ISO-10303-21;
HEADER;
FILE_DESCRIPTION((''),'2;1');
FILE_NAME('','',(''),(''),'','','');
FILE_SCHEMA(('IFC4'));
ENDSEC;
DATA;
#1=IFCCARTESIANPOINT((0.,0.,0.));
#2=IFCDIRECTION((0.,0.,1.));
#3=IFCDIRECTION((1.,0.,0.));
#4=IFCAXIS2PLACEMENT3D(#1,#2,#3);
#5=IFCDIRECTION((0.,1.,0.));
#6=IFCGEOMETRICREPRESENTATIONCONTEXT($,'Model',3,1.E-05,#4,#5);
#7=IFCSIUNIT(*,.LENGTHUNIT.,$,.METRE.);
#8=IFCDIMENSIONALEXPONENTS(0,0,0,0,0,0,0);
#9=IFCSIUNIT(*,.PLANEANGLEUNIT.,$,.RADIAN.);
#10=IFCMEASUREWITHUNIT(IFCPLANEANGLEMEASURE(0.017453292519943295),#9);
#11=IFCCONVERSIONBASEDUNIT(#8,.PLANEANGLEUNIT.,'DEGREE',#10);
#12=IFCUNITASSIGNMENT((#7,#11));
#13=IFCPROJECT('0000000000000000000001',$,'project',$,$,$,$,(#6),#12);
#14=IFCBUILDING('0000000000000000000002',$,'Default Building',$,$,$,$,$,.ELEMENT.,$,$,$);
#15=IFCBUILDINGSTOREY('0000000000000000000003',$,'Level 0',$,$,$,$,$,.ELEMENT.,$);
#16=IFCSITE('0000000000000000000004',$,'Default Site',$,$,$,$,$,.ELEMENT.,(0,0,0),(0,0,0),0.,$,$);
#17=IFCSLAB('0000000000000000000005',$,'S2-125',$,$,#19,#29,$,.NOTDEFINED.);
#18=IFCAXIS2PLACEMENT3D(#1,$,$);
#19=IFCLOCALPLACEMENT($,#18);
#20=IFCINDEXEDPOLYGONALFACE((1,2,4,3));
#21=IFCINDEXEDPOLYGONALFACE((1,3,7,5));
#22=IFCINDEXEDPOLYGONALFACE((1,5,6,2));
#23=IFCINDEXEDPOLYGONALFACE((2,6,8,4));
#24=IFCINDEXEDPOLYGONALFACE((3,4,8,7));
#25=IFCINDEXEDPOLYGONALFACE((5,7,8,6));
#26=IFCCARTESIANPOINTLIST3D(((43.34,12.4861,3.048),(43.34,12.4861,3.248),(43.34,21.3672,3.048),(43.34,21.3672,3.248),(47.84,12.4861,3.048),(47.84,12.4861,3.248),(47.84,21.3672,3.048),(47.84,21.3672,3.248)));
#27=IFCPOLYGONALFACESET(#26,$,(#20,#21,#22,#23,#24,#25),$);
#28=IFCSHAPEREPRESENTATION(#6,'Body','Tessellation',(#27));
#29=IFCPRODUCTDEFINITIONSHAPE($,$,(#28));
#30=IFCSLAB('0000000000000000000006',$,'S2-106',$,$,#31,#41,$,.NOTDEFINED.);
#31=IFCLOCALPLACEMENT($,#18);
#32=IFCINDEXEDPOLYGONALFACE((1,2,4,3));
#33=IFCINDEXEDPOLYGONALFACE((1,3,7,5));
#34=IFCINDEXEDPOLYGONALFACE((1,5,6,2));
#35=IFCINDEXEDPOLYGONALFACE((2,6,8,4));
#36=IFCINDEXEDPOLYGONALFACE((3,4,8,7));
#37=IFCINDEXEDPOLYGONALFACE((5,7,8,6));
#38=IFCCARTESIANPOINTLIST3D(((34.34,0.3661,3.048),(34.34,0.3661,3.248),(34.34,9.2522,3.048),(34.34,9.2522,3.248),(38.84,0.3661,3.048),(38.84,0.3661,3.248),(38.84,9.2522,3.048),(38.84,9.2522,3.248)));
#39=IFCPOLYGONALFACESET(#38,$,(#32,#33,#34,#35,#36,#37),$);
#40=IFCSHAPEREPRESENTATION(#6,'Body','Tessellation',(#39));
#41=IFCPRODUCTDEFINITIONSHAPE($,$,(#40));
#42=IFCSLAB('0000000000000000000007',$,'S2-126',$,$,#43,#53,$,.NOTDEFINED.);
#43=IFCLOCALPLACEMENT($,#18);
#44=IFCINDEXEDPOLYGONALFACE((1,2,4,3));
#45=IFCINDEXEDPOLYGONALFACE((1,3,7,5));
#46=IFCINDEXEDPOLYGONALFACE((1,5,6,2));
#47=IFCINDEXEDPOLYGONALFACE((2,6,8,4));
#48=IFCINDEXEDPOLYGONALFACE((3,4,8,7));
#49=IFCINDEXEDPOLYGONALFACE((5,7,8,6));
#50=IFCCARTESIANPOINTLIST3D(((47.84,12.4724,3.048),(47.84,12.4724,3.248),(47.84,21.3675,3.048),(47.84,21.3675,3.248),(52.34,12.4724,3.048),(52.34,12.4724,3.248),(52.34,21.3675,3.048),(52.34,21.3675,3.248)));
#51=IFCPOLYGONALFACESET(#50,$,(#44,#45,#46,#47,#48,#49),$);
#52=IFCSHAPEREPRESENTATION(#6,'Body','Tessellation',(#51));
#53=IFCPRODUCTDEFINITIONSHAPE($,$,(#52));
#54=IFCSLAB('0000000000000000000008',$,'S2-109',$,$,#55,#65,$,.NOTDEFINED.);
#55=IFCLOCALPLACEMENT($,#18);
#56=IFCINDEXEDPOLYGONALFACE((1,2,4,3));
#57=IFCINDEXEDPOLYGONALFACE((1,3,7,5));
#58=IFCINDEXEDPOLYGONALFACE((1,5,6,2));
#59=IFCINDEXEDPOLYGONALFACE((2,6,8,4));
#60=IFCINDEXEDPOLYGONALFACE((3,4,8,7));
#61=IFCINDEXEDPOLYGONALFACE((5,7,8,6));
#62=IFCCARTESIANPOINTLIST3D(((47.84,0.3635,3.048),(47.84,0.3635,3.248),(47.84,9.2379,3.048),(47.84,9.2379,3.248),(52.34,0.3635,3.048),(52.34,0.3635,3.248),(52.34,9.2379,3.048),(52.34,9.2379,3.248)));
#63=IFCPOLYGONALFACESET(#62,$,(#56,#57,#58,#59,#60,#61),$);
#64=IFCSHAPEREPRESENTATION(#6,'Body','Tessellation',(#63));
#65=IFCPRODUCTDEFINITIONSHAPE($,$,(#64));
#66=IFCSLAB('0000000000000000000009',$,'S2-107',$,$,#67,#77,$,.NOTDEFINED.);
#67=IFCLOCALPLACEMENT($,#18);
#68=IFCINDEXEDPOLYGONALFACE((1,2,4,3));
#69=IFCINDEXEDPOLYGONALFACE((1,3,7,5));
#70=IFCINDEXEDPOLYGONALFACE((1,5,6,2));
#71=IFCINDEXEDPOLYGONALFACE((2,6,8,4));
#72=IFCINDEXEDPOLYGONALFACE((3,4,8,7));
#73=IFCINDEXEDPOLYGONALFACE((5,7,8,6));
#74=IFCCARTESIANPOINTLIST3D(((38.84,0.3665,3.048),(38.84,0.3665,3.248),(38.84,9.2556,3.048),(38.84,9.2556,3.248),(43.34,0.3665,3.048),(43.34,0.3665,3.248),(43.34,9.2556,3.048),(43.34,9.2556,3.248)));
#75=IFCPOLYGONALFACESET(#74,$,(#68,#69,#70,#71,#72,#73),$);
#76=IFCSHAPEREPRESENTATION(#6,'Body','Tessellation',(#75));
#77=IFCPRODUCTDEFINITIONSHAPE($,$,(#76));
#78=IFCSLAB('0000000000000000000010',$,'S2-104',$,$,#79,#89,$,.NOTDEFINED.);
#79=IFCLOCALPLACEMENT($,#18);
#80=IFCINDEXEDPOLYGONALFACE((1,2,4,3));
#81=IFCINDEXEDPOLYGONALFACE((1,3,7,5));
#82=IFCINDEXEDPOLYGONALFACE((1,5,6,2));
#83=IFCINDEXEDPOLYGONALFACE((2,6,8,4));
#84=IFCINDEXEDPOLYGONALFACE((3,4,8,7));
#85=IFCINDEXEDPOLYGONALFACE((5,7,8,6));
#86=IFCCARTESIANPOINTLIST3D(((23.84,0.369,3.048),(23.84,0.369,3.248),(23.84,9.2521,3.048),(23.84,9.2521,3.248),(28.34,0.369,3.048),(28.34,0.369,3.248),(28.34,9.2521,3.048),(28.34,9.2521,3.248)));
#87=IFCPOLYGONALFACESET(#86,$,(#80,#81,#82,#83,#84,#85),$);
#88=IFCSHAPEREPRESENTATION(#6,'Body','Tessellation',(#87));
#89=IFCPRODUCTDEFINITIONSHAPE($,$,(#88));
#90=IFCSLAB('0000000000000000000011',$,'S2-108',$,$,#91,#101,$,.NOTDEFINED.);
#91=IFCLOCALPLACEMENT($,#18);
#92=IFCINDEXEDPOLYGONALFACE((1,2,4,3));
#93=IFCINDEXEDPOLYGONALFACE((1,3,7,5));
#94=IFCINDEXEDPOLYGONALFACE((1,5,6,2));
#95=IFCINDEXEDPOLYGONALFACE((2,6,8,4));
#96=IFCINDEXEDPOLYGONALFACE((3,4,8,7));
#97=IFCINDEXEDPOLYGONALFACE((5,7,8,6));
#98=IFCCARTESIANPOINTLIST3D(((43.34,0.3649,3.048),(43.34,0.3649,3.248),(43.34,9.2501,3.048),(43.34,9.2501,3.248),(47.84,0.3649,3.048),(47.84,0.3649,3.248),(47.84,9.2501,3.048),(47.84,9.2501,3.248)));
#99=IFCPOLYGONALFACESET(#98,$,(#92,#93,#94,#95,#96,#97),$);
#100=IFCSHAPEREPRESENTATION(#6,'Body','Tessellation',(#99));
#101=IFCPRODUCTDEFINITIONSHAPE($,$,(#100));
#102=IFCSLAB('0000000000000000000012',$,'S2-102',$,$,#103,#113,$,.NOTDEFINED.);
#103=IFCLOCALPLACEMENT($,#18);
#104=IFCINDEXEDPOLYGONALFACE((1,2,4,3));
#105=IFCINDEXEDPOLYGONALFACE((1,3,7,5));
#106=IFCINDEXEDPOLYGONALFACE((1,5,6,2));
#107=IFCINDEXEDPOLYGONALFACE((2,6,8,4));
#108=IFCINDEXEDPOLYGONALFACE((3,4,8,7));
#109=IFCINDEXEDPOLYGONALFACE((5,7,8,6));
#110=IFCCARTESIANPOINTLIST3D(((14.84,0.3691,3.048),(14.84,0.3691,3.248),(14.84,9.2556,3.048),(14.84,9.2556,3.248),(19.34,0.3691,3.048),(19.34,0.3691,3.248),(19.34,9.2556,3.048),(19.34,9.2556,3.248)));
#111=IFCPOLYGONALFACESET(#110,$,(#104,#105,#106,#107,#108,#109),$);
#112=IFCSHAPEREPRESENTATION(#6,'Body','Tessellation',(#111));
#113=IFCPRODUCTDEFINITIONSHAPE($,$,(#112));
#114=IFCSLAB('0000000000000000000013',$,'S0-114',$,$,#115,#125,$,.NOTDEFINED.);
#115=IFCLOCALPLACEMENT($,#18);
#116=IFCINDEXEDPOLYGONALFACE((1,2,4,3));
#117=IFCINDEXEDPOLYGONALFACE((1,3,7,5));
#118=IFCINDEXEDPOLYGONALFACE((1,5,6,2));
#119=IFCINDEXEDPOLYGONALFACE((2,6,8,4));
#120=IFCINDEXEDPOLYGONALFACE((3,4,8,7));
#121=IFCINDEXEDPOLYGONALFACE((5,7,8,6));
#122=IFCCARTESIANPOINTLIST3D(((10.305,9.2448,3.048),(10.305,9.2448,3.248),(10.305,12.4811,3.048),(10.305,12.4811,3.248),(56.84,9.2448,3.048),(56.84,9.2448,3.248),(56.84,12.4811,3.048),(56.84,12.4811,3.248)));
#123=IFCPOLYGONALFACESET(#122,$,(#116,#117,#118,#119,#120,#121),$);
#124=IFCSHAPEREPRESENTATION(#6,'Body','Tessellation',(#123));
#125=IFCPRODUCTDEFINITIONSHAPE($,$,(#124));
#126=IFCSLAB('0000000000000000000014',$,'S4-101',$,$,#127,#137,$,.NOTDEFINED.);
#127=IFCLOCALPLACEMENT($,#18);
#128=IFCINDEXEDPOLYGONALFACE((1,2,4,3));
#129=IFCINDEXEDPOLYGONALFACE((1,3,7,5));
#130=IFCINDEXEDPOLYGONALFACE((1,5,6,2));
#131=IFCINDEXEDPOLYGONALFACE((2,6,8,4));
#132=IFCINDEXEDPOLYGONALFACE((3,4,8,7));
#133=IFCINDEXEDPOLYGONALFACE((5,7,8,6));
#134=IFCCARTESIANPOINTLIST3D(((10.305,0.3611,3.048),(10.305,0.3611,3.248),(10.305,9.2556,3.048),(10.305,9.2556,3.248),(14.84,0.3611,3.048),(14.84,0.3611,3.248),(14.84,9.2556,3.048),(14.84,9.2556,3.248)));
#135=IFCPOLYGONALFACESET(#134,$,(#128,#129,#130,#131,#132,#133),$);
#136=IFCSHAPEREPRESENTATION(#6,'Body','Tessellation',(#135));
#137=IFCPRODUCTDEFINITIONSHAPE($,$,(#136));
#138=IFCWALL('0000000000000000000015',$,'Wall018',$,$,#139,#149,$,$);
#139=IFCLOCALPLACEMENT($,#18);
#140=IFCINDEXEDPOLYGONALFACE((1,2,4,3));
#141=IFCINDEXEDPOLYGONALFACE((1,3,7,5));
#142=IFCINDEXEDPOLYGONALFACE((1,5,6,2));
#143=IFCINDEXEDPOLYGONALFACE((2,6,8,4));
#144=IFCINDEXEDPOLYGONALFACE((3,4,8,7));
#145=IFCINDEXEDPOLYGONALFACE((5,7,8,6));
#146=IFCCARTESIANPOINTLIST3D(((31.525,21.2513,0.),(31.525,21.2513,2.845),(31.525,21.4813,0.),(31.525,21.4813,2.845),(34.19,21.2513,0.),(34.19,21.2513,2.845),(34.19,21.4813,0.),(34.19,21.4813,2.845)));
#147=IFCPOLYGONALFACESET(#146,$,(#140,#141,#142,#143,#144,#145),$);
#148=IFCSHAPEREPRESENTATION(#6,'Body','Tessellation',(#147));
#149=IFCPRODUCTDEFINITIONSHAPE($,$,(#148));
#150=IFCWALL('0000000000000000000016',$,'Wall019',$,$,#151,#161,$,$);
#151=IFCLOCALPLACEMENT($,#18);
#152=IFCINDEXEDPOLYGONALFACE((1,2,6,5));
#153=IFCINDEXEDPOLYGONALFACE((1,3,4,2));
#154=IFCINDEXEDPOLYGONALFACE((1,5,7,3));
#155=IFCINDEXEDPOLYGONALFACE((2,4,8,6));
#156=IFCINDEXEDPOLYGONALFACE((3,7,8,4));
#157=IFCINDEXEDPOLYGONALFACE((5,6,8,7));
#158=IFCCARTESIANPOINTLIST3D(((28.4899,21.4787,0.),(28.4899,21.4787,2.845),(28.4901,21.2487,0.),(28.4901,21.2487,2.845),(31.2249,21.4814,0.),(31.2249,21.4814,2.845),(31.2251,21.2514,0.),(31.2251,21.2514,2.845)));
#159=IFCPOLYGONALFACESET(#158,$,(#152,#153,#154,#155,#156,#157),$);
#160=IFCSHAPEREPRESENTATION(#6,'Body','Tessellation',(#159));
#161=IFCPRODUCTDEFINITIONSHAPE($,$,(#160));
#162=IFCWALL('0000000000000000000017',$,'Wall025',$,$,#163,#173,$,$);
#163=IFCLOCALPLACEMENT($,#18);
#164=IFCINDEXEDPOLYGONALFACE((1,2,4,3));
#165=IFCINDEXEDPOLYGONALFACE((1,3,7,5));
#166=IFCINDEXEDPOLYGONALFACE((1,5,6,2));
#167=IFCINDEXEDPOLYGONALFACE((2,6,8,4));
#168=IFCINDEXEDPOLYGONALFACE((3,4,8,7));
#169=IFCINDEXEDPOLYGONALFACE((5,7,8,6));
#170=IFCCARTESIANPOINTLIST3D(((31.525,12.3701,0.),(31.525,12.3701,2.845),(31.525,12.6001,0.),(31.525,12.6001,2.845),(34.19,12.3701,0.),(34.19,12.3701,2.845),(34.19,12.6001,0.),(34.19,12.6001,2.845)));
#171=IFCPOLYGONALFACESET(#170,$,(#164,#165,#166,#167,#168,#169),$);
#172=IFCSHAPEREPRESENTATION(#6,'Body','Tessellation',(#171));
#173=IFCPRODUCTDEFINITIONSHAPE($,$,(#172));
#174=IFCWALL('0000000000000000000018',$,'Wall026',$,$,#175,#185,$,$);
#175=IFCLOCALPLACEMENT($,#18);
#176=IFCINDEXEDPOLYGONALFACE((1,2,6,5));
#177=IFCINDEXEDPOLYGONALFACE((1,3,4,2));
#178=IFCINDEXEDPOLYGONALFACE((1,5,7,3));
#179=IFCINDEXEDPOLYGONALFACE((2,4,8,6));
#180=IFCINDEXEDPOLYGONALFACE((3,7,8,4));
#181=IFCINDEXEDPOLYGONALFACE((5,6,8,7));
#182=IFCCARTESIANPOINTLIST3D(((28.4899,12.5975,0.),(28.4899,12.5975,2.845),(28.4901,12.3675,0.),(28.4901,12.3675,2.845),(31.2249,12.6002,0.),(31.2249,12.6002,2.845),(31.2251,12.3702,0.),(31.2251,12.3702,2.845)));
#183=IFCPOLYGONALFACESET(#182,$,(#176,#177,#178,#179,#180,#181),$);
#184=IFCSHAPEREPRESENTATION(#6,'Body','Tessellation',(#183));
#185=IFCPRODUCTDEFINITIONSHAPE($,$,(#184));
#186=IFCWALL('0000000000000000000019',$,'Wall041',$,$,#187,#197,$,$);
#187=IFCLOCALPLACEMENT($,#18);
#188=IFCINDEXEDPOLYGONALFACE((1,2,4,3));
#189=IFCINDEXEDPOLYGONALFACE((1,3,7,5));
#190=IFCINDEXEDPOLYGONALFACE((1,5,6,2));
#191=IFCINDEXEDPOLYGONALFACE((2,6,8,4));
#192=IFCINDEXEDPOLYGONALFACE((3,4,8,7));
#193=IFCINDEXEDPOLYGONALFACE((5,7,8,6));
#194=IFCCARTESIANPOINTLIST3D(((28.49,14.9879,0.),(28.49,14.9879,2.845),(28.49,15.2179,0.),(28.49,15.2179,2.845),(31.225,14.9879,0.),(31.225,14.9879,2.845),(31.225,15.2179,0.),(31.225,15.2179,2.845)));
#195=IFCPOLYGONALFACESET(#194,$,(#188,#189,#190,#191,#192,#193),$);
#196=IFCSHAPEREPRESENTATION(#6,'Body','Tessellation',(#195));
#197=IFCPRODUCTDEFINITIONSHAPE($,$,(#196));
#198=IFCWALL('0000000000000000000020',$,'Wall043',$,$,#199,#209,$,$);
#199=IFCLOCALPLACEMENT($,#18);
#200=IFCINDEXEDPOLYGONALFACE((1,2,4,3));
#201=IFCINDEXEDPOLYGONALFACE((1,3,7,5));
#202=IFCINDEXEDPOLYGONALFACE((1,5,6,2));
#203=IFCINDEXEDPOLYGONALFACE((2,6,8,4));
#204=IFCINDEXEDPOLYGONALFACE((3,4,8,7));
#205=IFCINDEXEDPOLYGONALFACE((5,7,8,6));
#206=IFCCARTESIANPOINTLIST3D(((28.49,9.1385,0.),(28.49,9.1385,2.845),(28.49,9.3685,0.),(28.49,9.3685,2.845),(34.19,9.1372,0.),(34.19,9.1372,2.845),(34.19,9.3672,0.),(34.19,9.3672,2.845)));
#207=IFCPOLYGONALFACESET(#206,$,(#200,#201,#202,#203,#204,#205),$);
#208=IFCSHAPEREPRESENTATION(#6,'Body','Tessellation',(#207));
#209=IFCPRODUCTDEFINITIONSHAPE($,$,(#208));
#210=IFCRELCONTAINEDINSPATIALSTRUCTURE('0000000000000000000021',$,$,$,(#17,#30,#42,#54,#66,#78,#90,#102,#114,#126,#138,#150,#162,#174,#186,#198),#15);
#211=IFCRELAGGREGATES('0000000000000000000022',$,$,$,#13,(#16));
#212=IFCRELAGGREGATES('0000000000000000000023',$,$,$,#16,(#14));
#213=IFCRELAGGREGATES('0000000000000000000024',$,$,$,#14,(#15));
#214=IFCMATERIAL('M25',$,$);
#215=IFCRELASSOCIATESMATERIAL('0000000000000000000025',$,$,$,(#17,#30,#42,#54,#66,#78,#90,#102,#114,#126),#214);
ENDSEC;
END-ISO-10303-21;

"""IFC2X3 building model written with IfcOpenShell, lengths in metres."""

from ifc_helpers import new_model, entity, si_unit, converted_unit, direction, frame, frame_2d, origin_with_axes, place, context, project, spatial, rectangle, extrude, material, element, save


model = new_model("IFC2X3")

# Units and contexts
model_context = context("Model", 3, precision=1e-05, world=origin_with_axes(), true_north=direction((0.0, 1.0, 0.0)))
ifc_project = project(units=[si_unit("LENGTHUNIT", "METRE"), converted_unit("PLANEANGLEUNIT", "DEGREE", entity("IfcPlaneAngleMeasure", 0.017453292519943295), si_unit("PLANEANGLEUNIT", "RADIAN"), dimensions=[0, 0, 0, 0, 0, 0, 0])], contexts=[model_context])

# Site, building, storey
site = spatial("IfcSite", under=ifc_project, Name="Default Site", CompositionType="ELEMENT", RefLatitude=(0, 0, 0), RefLongitude=(0, 0, 0), RefElevation=0.0)
building = spatial("IfcBuilding", under=site, Name="Default Building", CompositionType="ELEMENT")
storey = spatial("IfcBuildingStorey", under=building, Name="Level 0", CompositionType="ELEMENT")

# Slabs
ifc_material = material(Name="M25")
placement = place(None, origin_with_axes())
element("IfcSlab", 1, at=placement, inside=storey, material=ifc_material, Name="S2-125", PredefinedType="NOTDEFINED", context=model_context, shape_type="SweptSolid", body=[
    extrude(rectangle(XDim=4.5, YDim=8.8811, at=frame_2d((0.0, 0.0), x_axis=(1.0, 0.0, 0.0))), frame((45.59, 16.9266, 3.048), z_axis=(0.0, 0.0, 1.0), x_axis=(1.0, 0.0, 0.0)), (0.0, 0.0, 1.0), 0.2),
])
element("IfcSlab", 2, at=placement, inside=storey, material=ifc_material, Name="S2-106", PredefinedType="NOTDEFINED", context=model_context, shape_type="SweptSolid", body=[
    extrude(rectangle(XDim=4.5, YDim=8.8861, at=frame_2d((0.0, 0.0), x_axis=(1.0, 0.0, 0.0))), frame((36.59, 4.8092, 3.048), z_axis=(0.0, 0.0, 1.0), x_axis=(1.0, 0.0, 0.0)), (0.0, 0.0, 1.0), 0.2),
])
element("IfcSlab", 3, at=placement, inside=storey, material=ifc_material, Name="S2-126", PredefinedType="NOTDEFINED", context=model_context, shape_type="SweptSolid", body=[
    extrude(rectangle(XDim=4.5, YDim=8.8951, at=frame_2d((0.0, 0.0), x_axis=(1.0, 0.0, 0.0))), frame((50.09, 16.9199, 3.048), z_axis=(0.0, 0.0, 1.0), x_axis=(1.0, 0.0, 0.0)), (0.0, 0.0, 1.0), 0.2),
])
element("IfcSlab", 4, at=placement, inside=storey, material=ifc_material, Name="S2-109", PredefinedType="NOTDEFINED", context=model_context, shape_type="SweptSolid", body=[
    extrude(rectangle(XDim=4.5, YDim=8.8744, at=frame_2d((0.0, 0.0), x_axis=(1.0, 0.0, 0.0))), frame((50.09, 4.8007, 3.048), z_axis=(0.0, 0.0, 1.0), x_axis=(1.0, 0.0, 0.0)), (0.0, 0.0, 1.0), 0.2),
])
element("IfcSlab", 5, at=placement, inside=storey, material=ifc_material, Name="S2-107", PredefinedType="NOTDEFINED", context=model_context, shape_type="SweptSolid", body=[
    extrude(rectangle(XDim=4.5, YDim=8.8891, at=frame_2d((0.0, 0.0), x_axis=(1.0, 0.0, 0.0))), frame((41.09, 4.811, 3.048), z_axis=(0.0, 0.0, 1.0), x_axis=(1.0, 0.0, 0.0)), (0.0, 0.0, 1.0), 0.2),
])
element("IfcSlab", 6, at=placement, inside=storey, material=ifc_material, Name="S2-104", PredefinedType="NOTDEFINED", context=model_context, shape_type="SweptSolid", body=[
    extrude(rectangle(XDim=4.5, YDim=8.8831, at=frame_2d((0.0, 0.0), x_axis=(1.0, 0.0, 0.0))), frame((26.09, 4.8106, 3.048), z_axis=(0.0, 0.0, 1.0), x_axis=(1.0, 0.0, 0.0)), (0.0, 0.0, 1.0), 0.2),
])
element("IfcSlab", 7, at=placement, inside=storey, material=ifc_material, Name="S2-108", PredefinedType="NOTDEFINED", context=model_context, shape_type="SweptSolid", body=[
    extrude(rectangle(XDim=4.5, YDim=8.8852, at=frame_2d((0.0, 0.0), x_axis=(1.0, 0.0, 0.0))), frame((45.59, 4.8075, 3.048), z_axis=(0.0, 0.0, 1.0), x_axis=(1.0, 0.0, 0.0)), (0.0, 0.0, 1.0), 0.2),
])
element("IfcSlab", 8, at=placement, inside=storey, material=ifc_material, Name="S2-102", PredefinedType="NOTDEFINED", context=model_context, shape_type="SweptSolid", body=[
    extrude(rectangle(XDim=4.5, YDim=8.8865, at=frame_2d((0.0, 0.0), x_axis=(1.0, 0.0, 0.0))), frame((17.09, 4.8123, 3.048), z_axis=(0.0, 0.0, 1.0), x_axis=(1.0, 0.0, 0.0)), (0.0, 0.0, 1.0), 0.2),
])
element("IfcSlab", 9, at=placement, inside=storey, material=ifc_material, Name="S0-114", PredefinedType="NOTDEFINED", context=model_context, shape_type="SweptSolid", body=[
    extrude(rectangle(XDim=46.535, YDim=3.2363, at=frame_2d((0.0, 0.0), x_axis=(1.0, 0.0, 0.0))), frame((33.5725, 10.863, 3.048), z_axis=(0.0, 0.0, 1.0), x_axis=(1.0, 0.0, 0.0)), (0.0, 0.0, 1.0), 0.2),
])
element("IfcSlab", 10, at=placement, inside=storey, material=ifc_material, Name="S4-101", PredefinedType="NOTDEFINED", context=model_context, shape_type="SweptSolid", body=[
    extrude(rectangle(XDim=4.535, YDim=8.8945, at=frame_2d((0.0, 0.0), x_axis=(1.0, 0.0, 0.0))), frame((12.5725, 4.8083, 3.048), z_axis=(0.0, 0.0, 1.0), x_axis=(1.0, 0.0, 0.0)), (0.0, 0.0, 1.0), 0.2),
])

# Walls
element("IfcWall", 11, at=placement, inside=storey, Name="Wall018", context=model_context, shape_type="SweptSolid", body=[
    extrude(rectangle(XDim=2.665, YDim=0.23, at=frame_2d((0.0, 0.0), x_axis=(-1.0, 0.0, 0.0))), frame((32.8575, 21.3663, 0.0), z_axis=(0.0, 0.0, 1.0), x_axis=(1.0, 0.0, 0.0)), (0.0, 0.0, 1.0), 2.845),
])
element("IfcWall", 12, at=placement, inside=storey, Name="Wall019", context=model_context, shape_type="SweptSolid", body=[
    extrude(rectangle(XDim=2.735, YDim=0.23, at=frame_2d((0.0, 0.0), x_axis=(-1.0, -0.00098, 0.0))), frame((29.8575, 21.365, 0.0), z_axis=(0.0, 0.0, 1.0), x_axis=(1.0, 0.0, 0.0)), (0.0, 0.0, 1.0), 2.845),
])
element("IfcWall", 13, at=placement, inside=storey, Name="Wall025", context=model_context, shape_type="SweptSolid", body=[
    extrude(rectangle(XDim=2.665, YDim=0.23, at=frame_2d((0.0, 0.0), x_axis=(-1.0, 0.0, 0.0))), frame((32.8575, 12.4851, 0.0), z_axis=(0.0, 0.0, 1.0), x_axis=(1.0, 0.0, 0.0)), (0.0, 0.0, 1.0), 2.845),
])
element("IfcWall", 14, at=placement, inside=storey, Name="Wall026", context=model_context, shape_type="SweptSolid", body=[
    extrude(rectangle(XDim=2.735, YDim=0.23, at=frame_2d((0.0, 0.0), x_axis=(-1.0, -0.00098, 0.0))), frame((29.8575, 12.4838, 0.0), z_axis=(0.0, 0.0, 1.0), x_axis=(1.0, 0.0, 0.0)), (0.0, 0.0, 1.0), 2.845),
])
element("IfcWall", 15, at=placement, inside=storey, Name="Wall041", context=model_context, shape_type="SweptSolid", body=[
    extrude(rectangle(XDim=2.735, YDim=0.23, at=frame_2d((0.0, 0.0), x_axis=(-1.0, 0.0, 0.0))), frame((29.8575, 15.1029, 0.0), z_axis=(0.0, 0.0, 1.0), x_axis=(1.0, 0.0, 0.0)), (0.0, 0.0, 1.0), 2.845),
])
element("IfcWall", 16, at=placement, inside=storey, Name="Wall043", context=model_context, shape_type="SweptSolid", body=[
    extrude(rectangle(XDim=5.7, YDim=0.23, at=frame_2d((0.0, 0.0), x_axis=(1.0, -0.000224, 0.0))), frame((31.34, 9.2529, 0.0), z_axis=(0.0, 0.0, 1.0), x_axis=(1.0, 0.0, 0.0)), (0.0, 0.0, 1.0), 2.845),
])

save(model, "model.ifc")
